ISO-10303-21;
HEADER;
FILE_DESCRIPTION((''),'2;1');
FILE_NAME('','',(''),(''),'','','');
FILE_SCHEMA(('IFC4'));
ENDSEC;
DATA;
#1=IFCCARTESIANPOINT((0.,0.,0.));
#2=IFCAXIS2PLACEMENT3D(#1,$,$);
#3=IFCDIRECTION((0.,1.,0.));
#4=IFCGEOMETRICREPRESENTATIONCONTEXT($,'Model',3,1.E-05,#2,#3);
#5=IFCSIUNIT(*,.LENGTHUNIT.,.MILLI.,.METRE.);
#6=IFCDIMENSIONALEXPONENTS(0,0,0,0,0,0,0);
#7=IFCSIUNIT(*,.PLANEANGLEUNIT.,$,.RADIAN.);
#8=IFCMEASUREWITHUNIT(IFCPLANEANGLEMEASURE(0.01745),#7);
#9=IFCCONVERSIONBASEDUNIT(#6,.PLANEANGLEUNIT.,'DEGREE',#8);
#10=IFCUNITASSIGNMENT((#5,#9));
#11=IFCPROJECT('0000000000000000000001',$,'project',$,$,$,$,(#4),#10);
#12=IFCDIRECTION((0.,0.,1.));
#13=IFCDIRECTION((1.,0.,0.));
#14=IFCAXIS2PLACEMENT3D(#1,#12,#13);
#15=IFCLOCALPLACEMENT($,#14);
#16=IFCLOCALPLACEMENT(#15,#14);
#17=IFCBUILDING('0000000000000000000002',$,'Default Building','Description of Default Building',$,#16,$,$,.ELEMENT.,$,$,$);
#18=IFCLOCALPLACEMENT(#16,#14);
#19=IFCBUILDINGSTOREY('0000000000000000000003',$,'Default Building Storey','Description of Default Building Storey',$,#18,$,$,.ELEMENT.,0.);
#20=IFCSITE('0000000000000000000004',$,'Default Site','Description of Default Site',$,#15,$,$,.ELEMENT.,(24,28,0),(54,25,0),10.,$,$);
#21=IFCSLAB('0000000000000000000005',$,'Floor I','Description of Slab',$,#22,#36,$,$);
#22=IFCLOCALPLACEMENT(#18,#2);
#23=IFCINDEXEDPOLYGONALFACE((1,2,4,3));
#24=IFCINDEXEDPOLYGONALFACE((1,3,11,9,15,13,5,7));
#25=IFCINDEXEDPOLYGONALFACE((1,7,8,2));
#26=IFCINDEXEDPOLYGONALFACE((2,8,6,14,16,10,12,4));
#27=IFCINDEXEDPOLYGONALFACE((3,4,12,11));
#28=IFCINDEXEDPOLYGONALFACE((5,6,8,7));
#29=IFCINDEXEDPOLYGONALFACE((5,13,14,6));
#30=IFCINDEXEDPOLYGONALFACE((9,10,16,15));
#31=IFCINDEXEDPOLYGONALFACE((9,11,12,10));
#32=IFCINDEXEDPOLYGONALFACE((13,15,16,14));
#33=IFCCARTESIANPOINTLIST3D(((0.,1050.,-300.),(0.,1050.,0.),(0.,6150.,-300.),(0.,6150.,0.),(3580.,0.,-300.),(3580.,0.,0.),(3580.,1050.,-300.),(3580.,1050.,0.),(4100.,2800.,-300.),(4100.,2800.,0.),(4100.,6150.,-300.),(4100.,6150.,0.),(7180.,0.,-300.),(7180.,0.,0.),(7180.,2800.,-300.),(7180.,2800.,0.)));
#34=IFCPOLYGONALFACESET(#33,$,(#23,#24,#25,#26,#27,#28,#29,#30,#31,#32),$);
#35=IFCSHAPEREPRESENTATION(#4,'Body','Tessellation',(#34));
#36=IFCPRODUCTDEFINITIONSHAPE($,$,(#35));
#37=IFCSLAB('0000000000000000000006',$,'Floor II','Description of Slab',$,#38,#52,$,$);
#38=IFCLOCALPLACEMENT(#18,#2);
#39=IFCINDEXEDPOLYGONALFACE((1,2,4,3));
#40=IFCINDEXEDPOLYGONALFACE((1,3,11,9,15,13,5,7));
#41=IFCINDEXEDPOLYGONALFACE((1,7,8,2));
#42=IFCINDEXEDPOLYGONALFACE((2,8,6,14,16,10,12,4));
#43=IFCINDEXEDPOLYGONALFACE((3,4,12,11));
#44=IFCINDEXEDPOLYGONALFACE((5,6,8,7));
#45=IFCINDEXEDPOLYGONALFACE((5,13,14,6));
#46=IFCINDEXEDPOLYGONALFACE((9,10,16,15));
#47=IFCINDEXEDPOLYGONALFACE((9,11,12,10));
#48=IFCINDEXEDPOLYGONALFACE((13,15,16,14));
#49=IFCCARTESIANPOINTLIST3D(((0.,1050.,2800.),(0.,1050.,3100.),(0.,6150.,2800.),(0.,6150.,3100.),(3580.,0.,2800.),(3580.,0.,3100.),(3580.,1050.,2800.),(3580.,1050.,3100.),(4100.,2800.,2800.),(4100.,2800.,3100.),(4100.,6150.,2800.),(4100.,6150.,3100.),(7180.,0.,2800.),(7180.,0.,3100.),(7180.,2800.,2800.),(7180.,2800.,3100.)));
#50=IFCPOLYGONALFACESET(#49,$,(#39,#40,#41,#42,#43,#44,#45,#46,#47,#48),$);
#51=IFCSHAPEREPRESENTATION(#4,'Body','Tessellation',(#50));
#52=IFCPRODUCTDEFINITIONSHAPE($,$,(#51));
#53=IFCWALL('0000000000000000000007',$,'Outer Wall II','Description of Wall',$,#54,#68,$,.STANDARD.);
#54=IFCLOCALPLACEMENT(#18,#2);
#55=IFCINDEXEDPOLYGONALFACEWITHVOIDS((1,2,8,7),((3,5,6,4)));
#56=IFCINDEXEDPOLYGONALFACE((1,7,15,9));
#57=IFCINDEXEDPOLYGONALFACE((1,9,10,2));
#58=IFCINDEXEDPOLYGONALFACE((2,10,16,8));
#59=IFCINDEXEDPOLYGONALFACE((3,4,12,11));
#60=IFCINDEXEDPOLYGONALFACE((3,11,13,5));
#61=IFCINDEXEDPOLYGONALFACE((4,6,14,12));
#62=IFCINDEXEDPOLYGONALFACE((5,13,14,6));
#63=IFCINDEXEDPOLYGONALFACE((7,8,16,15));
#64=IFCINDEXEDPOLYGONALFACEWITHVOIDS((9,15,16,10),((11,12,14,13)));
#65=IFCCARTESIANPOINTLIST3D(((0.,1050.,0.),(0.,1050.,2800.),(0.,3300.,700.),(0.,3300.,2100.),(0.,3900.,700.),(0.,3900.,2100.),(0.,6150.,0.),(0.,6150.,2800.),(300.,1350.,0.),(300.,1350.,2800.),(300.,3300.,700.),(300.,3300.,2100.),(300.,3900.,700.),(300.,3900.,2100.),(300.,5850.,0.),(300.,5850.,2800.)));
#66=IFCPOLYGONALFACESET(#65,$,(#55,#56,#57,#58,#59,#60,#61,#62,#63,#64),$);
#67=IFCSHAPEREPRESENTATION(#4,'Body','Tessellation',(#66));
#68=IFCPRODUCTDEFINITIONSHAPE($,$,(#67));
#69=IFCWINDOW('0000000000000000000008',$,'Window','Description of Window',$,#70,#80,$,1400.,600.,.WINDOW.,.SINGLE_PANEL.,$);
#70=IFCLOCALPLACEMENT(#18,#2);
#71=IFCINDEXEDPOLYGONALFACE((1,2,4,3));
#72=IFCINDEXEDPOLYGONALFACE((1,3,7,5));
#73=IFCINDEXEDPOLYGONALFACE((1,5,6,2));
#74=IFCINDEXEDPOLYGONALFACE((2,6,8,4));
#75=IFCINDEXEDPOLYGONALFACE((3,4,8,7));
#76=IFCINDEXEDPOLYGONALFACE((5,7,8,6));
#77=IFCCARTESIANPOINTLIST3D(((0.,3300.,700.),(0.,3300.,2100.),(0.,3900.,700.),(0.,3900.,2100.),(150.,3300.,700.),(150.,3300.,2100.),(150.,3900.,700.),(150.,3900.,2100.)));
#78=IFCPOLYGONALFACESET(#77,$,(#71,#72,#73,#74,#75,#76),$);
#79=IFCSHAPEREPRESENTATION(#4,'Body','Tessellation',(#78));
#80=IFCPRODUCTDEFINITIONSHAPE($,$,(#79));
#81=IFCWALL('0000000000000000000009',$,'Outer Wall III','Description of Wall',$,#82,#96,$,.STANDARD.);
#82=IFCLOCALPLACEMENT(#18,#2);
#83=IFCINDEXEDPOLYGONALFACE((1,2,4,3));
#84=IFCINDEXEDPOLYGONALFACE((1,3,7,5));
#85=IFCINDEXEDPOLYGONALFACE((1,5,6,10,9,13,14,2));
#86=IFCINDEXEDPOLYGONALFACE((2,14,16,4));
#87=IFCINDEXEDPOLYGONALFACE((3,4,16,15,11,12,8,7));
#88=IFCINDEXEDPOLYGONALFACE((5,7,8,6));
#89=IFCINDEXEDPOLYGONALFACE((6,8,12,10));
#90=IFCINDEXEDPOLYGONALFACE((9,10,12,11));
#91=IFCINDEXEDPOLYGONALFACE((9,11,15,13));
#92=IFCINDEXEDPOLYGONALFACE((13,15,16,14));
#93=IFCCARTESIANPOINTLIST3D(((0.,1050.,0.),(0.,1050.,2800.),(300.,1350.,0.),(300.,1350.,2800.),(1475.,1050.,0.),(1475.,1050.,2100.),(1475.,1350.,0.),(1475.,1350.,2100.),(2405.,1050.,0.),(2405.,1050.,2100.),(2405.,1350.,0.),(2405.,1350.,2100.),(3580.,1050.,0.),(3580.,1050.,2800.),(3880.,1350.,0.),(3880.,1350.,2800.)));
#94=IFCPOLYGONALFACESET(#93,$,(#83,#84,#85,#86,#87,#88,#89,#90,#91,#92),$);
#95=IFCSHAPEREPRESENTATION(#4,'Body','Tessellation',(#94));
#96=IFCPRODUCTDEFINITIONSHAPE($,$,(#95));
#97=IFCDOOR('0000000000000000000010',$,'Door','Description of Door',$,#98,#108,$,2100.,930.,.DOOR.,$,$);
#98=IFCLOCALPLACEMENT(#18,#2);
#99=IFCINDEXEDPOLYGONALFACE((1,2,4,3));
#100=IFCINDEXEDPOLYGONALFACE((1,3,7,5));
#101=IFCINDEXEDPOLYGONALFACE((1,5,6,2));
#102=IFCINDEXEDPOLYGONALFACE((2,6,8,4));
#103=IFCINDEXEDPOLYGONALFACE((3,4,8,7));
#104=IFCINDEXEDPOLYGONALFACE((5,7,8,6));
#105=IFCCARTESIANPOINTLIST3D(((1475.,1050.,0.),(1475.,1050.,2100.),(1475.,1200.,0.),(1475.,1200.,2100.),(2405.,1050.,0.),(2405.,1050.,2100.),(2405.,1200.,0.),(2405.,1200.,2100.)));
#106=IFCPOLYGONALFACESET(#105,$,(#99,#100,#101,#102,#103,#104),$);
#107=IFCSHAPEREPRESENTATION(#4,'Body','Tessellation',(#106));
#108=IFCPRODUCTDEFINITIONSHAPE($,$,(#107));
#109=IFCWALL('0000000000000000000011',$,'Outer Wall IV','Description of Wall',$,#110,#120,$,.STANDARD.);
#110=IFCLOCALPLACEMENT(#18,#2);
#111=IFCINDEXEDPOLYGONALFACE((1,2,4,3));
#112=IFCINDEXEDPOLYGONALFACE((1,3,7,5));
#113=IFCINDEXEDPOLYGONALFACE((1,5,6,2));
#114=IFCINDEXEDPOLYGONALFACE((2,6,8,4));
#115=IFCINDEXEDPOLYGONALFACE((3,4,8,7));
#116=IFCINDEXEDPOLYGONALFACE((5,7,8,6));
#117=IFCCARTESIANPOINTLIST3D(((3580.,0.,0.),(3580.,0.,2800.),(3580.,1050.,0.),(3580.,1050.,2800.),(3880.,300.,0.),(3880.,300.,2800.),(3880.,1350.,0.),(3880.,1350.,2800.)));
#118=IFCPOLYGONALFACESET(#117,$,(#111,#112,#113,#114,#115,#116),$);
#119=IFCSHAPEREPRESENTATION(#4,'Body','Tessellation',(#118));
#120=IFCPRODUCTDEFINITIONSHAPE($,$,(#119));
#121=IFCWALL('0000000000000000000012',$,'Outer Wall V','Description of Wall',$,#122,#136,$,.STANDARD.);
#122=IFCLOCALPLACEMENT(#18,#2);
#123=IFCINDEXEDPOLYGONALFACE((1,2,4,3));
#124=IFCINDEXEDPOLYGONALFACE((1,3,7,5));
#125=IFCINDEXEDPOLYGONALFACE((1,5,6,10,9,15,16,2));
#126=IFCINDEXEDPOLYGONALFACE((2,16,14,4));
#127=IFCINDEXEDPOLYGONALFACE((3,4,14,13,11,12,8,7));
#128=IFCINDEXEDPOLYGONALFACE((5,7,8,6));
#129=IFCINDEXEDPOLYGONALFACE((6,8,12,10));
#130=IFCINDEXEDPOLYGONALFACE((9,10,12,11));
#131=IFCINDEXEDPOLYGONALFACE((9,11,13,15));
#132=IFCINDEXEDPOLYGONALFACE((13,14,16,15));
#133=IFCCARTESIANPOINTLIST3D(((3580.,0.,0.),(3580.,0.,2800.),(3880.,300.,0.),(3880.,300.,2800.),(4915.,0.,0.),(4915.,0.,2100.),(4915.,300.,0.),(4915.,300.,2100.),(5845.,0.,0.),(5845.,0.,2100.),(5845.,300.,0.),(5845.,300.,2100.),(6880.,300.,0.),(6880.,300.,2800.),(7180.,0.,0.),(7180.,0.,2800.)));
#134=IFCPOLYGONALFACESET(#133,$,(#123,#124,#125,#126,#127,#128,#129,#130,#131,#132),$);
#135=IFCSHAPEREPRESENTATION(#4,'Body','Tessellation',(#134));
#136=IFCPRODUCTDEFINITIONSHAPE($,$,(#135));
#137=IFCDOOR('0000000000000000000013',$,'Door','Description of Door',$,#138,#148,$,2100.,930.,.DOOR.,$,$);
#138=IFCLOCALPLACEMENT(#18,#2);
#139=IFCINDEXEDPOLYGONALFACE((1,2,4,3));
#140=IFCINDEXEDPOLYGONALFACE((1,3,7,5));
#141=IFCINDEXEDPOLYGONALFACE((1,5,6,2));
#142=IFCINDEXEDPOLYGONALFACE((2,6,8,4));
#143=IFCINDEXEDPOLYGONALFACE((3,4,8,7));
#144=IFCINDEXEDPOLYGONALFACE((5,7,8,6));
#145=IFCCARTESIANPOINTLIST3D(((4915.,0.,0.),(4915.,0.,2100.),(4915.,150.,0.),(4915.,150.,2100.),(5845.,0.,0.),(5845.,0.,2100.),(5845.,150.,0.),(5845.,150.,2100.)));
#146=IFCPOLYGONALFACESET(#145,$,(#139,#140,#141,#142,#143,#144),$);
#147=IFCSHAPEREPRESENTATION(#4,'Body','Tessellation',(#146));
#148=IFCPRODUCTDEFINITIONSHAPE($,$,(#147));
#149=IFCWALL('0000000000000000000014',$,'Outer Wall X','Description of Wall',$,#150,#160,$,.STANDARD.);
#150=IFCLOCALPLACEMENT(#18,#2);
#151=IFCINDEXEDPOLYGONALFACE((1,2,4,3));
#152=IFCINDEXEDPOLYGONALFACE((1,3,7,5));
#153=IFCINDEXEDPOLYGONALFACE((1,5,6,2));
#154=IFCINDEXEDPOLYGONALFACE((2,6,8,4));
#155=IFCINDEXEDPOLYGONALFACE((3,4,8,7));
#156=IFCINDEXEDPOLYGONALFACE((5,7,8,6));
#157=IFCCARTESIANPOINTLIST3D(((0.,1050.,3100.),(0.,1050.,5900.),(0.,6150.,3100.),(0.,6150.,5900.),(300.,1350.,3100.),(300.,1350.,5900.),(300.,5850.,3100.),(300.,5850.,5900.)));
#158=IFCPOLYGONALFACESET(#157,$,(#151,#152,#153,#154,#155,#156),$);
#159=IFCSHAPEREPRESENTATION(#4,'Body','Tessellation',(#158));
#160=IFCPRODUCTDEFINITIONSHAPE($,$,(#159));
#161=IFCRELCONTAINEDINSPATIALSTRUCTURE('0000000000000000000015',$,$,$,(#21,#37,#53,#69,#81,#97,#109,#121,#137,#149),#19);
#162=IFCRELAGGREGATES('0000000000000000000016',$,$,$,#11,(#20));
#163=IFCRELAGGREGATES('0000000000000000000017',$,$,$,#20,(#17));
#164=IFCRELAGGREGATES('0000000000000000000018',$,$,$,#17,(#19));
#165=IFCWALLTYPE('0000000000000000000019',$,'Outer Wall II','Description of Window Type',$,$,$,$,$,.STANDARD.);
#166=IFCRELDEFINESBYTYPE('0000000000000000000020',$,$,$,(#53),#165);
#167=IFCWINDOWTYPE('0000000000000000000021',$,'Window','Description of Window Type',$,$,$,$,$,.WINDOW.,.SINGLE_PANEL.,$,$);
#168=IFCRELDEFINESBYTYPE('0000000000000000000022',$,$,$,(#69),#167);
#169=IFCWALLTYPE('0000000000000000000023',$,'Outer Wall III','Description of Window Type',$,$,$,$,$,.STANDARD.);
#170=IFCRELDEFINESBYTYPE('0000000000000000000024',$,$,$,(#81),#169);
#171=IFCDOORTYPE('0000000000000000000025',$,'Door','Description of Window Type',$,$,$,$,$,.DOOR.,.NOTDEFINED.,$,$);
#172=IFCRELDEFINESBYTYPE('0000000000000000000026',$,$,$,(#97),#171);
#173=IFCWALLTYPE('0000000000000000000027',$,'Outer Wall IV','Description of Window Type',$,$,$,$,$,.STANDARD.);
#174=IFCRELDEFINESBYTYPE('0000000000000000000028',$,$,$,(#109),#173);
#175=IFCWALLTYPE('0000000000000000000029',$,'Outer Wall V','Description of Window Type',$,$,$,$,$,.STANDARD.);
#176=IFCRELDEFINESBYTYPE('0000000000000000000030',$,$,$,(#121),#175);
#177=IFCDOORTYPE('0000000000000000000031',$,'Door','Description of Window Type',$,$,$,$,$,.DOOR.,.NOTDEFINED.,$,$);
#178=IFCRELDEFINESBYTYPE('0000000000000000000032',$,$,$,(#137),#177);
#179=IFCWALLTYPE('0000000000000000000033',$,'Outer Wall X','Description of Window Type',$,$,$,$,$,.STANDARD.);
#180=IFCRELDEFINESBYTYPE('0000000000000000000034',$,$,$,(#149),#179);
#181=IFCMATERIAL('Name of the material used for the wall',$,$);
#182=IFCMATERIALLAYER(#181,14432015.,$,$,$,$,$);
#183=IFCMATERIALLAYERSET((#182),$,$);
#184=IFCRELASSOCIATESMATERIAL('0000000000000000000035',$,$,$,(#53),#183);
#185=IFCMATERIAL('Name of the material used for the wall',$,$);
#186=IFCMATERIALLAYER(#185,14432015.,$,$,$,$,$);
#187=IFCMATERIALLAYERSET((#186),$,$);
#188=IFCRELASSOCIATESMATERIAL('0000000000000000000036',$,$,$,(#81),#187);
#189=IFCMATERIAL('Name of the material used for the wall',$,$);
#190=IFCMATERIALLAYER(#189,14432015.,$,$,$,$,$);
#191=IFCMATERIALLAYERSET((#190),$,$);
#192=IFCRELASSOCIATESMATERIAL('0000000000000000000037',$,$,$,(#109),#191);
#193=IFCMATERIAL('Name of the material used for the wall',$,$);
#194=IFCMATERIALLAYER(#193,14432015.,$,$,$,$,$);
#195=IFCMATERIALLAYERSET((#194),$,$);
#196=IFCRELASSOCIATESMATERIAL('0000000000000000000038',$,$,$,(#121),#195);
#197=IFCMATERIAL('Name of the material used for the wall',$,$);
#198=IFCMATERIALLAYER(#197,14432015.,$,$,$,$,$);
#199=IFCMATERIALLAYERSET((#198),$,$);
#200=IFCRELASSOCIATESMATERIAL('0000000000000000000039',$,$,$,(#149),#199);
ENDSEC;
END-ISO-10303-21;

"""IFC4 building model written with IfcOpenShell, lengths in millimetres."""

from ifc_helpers import new_model, entity, si_unit, converted_unit, direction, frame, origin, origin_with_axes, place, context, project, spatial, polyline, outline, extrude, material, layer, layer_set, layer_usage, type_object, element, fill, save


model = new_model("IFC4")

# Units and contexts
model_context = context("Model", 3, precision=1e-05, world=origin(), true_north=direction((0.0, 1.0, 0.0)))
ifc_project = project(units=[si_unit("LENGTHUNIT", "METRE", prefix="MILLI"), converted_unit("PLANEANGLEUNIT", "DEGREE", entity("IfcPlaneAngleMeasure", 0.01745), si_unit("PLANEANGLEUNIT", "RADIAN"), dimensions=[0, 0, 0, 0, 0, 0, 0])], contexts=[model_context])

# Site, building, storey
site_placement = place(None, origin_with_axes())
site = spatial("IfcSite", under=ifc_project, at=site_placement, Name="Default Site", Description="Description of Default Site", CompositionType="ELEMENT", RefLatitude=(24, 28, 0), RefLongitude=(54, 25, 0), RefElevation=10.0)
building_placement = place(site_placement, origin_with_axes())
building = spatial("IfcBuilding", under=site, at=building_placement, Name="Default Building", Description="Description of Default Building", CompositionType="ELEMENT")
storey_placement = place(building_placement, origin_with_axes())
storey = spatial("IfcBuildingStorey", under=building, at=storey_placement, Name="Default Building Storey", Description="Description of Default Building Storey", CompositionType="ELEMENT", Elevation=0.0)

# Slabs
for number, where, z_axis, x_axis, name in (
    (1, (0.0, 0.0, -300.0), (0.0, 0.0, 1.0), (1.0, 0.0, 0.0), "Floor I"),
    (2, (0.0, 0.0, 2800.0), (0.0, 0.0, 1.0), (1.0, 0.0, 0.0), "Floor II"),
):
    element("IfcSlab", number, at=place(storey_placement, frame(where, z_axis=z_axis, x_axis=x_axis)), inside=storey, Name=name, Description="Description of Slab", context=model_context, shape_type="SweptSolid", body=[
        extrude(outline(polyline([(0.0, 1050.0), (0.0, 6150.0), (4100.0, 6150.0), (4100.0, 2800.0), (7180.0, 2800.0), (7180.0, 0.0), (3580.0, 0.0), (3580.0, 1050.0), (0.0, 1050.0)])), origin_with_axes(), (0.0, 0.0, 1.0), 300.0),
    ])

# Wall, opening, window
ifc_material_1 = material(Name="Name of the material used for the wall")
ifc_layer_1 = layer(ifc_material_1, 14432015.0)
ifc_layer_set_1 = layer_set([ifc_layer_1])
ifc_layer_usage_1 = layer_usage(ifc_layer_set_1, "AXIS2", "POSITIVE", -7216007.5)
wall_type_1 = type_object("IfcWallType", Name="Outer Wall II", Description="Description of Window Type", PredefinedType="STANDARD")
wall_1_placement = place(storey_placement, frame((150.0, 6000.0, 0.0), z_axis=(0.0, 0.0, 1.0), x_axis=(0.0, -1.0, 0.0)))
wall_1 = element("IfcWall", 3, at=wall_1_placement, inside=storey, type_object=wall_type_1, material=ifc_layer_usage_1, Name="Outer Wall II", Description="Description of Wall", PredefinedType="STANDARD", context=model_context, shape_type="SweptSolid", body=[
    extrude(outline(polyline([(-150.0, -150.0), (150.0, 150.0), (4650.0, 150.0), (4950.0, -150.0), (-150.0, -150.0)])), origin_with_axes(), (0.0, 0.0, 1.0), 2800.0),
])
opening_1_placement = place(wall_1_placement, frame((2100.0, -150.0, 700.0), z_axis=(0.0, 0.0, 1.0), x_axis=(1.0, 0.0, 0.0)))
opening_1 = element("IfcOpeningElement", 4, at=opening_1_placement, cuts=wall_1, context=model_context, shape_type="SweptSolid", body=[
    extrude(outline(polyline([(0.0, 0.0), (0.0, 300.0), (600.0, 300.0), (600.0, 0.0), (0.0, 0.0)])), origin_with_axes(), (0.0, 0.0, 1.0), 1400.0),
])
window_type_1 = type_object("IfcWindowType", Name="Window", Description="Description of Window Type", PartitioningType="SINGLE_PANEL", PredefinedType="WINDOW")
window_1_placement = place(opening_1_placement, origin_with_axes())
window_1 = element("IfcWindow", 5, at=window_1_placement, inside=storey, type_object=window_type_1, Name="Window", Description="Description of Window", OverallHeight=1400.0, OverallWidth=600.0, PartitioningType="SINGLE_PANEL", PredefinedType="WINDOW", context=model_context, shape_type="SweptSolid", body=[
    extrude(outline(polyline([(0.0, 0.0), (0.0, 150.0), (600.0, 150.0), (600.0, 0.0), (0.0, 0.0)])), origin_with_axes(), (0.0, 0.0, 1.0), 1400.0),
])
fill(opening_1, window_1)

# Wall, opening, door
ifc_material_2 = material(Name="Name of the material used for the wall")
ifc_layer_2 = layer(ifc_material_2, 14432015.0)
ifc_layer_set_2 = layer_set([ifc_layer_2])
ifc_layer_usage_2 = layer_usage(ifc_layer_set_2, "AXIS2", "POSITIVE", -7216007.5)
wall_type_2 = type_object("IfcWallType", Name="Outer Wall III", Description="Description of Window Type", PredefinedType="STANDARD")
wall_2_placement = place(storey_placement, frame((150.0, 1200.0, 0.0), z_axis=(0.0, 0.0, 1.0), x_axis=(1.0, 0.0, 0.0)))
wall_2 = element("IfcWall", 6, at=wall_2_placement, inside=storey, type_object=wall_type_2, material=ifc_layer_usage_2, Name="Outer Wall III", Description="Description of Wall", PredefinedType="STANDARD", context=model_context, shape_type="SweptSolid", body=[
    extrude(outline(polyline([(-150.0, -150.0), (150.0, 150.0), (3730.0, 150.0), (3430.0, -150.0), (-150.0, -150.0)])), origin_with_axes(), (0.0, 0.0, 1.0), 2800.0),
])
opening_2_placement = place(wall_2_placement, frame((1325.0, -150.0, 0.0), z_axis=(0.0, 0.0, 1.0), x_axis=(1.0, 0.0, 0.0)))
opening_2 = element("IfcOpeningElement", 7, at=opening_2_placement, cuts=wall_2, context=model_context, shape_type="SweptSolid", body=[
    extrude(outline(polyline([(0.0, 0.0), (0.0, 300.0), (930.0, 300.0), (930.0, 0.0), (0.0, 0.0)])), origin_with_axes(), (0.0, 0.0, 1.0), 2100.0),
])
door_type_1 = type_object("IfcDoorType", Name="Door", Description="Description of Window Type", PredefinedType="DOOR")
door_1_placement = place(opening_2_placement, origin_with_axes())
door_1 = element("IfcDoor", 8, at=door_1_placement, inside=storey, type_object=door_type_1, Name="Door", Description="Description of Door", OverallHeight=2100.0, OverallWidth=930.0, PredefinedType="DOOR", context=model_context, shape_type="SweptSolid", body=[
    extrude(outline(polyline([(0.0, 0.0), (0.0, 150.0), (930.0, 150.0), (930.0, 0.0), (0.0, 0.0)])), origin_with_axes(), (0.0, 0.0, 1.0), 2100.0),
])
fill(opening_2, door_1)

# Wall
ifc_material_3 = material(Name="Name of the material used for the wall")
ifc_layer_3 = layer(ifc_material_3, 14432015.0)
ifc_layer_set_3 = layer_set([ifc_layer_3])
ifc_layer_usage_3 = layer_usage(ifc_layer_set_3, "AXIS2", "POSITIVE", -7216007.5)
wall_type_3 = type_object("IfcWallType", Name="Outer Wall IV", Description="Description of Window Type", PredefinedType="STANDARD")
wall_3_placement = place(storey_placement, frame((3730.0, 1200.0, 0.0), z_axis=(0.0, 0.0, 1.0), x_axis=(0.0, -1.0, 0.0)))
element("IfcWall", 9, at=wall_3_placement, inside=storey, type_object=wall_type_3, material=ifc_layer_usage_3, Name="Outer Wall IV", Description="Description of Wall", PredefinedType="STANDARD", context=model_context, shape_type="SweptSolid", body=[
    extrude(outline(polyline([(150.0, -150.0), (-150.0, 150.0), (900.0, 150.0), (1200.0, -150.0), (150.0, -150.0)])), origin_with_axes(), (0.0, 0.0, 1.0), 2800.0),
])

# Wall, opening, door
ifc_material_4 = material(Name="Name of the material used for the wall")
ifc_layer_4 = layer(ifc_material_4, 14432015.0)
ifc_layer_set_4 = layer_set([ifc_layer_4])
ifc_layer_usage_4 = layer_usage(ifc_layer_set_4, "AXIS2", "POSITIVE", -7216007.5)
wall_type_4 = type_object("IfcWallType", Name="Outer Wall V", Description="Description of Window Type", PredefinedType="STANDARD")
wall_4_placement = place(storey_placement, frame((3730.0, 150.0, 0.0), z_axis=(0.0, 0.0, 1.0), x_axis=(1.0, 0.0, 0.0)))
wall_4 = element("IfcWall", 10, at=wall_4_placement, inside=storey, type_object=wall_type_4, material=ifc_layer_usage_4, Name="Outer Wall V", Description="Description of Wall", PredefinedType="STANDARD", context=model_context, shape_type="SweptSolid", body=[
    extrude(outline(polyline([(-150.0, -150.0), (150.0, 150.0), (3150.0, 150.0), (3450.0, -150.0), (-150.0, -150.0)])), origin_with_axes(), (0.0, 0.0, 1.0), 2800.0),
])
opening_3_placement = place(wall_4_placement, frame((1185.0, -150.0, 0.0), z_axis=(0.0, 0.0, 1.0), x_axis=(1.0, 0.0, 0.0)))
opening_3 = element("IfcOpeningElement", 11, at=opening_3_placement, cuts=wall_4, context=model_context, shape_type="SweptSolid", body=[
    extrude(outline(polyline([(0.0, 0.0), (0.0, 300.0), (930.0, 300.0), (930.0, 0.0), (0.0, 0.0)])), origin_with_axes(), (0.0, 0.0, 1.0), 2100.0),
])
door_type_2 = type_object("IfcDoorType", Name="Door", Description="Description of Window Type", PredefinedType="DOOR")
door_2_placement = place(opening_3_placement, origin_with_axes())
door_2 = element("IfcDoor", 12, at=door_2_placement, inside=storey, type_object=door_type_2, Name="Door", Description="Description of Door", OverallHeight=2100.0, OverallWidth=930.0, PredefinedType="DOOR", context=model_context, shape_type="SweptSolid", body=[
    extrude(outline(polyline([(0.0, 0.0), (0.0, 150.0), (930.0, 150.0), (930.0, 0.0), (0.0, 0.0)])), origin_with_axes(), (0.0, 0.0, 1.0), 2100.0),
])
fill(opening_3, door_2)

# Wall
ifc_material_5 = material(Name="Name of the material used for the wall")
ifc_layer_5 = layer(ifc_material_5, 14432015.0)
ifc_layer_set_5 = layer_set([ifc_layer_5])
ifc_layer_usage_5 = layer_usage(ifc_layer_set_5, "AXIS2", "POSITIVE", -7216007.5)
wall_type_5 = type_object("IfcWallType", Name="Outer Wall X", Description="Description of Window Type", PredefinedType="STANDARD")
wall_5_placement = place(storey_placement, frame((150.0, 6000.0, 3100.0), z_axis=(0.0, 0.0, 1.0), x_axis=(0.0, -1.0, 0.0)))
element("IfcWall", 13, at=wall_5_placement, inside=storey, type_object=wall_type_5, material=ifc_layer_usage_5, Name="Outer Wall X", Description="Description of Wall", PredefinedType="STANDARD", context=model_context, shape_type="SweptSolid", body=[
    extrude(outline(polyline([(-150.0, -150.0), (150.0, 150.0), (4650.0, 150.0), (4950.0, -150.0), (-150.0, -150.0)])), origin_with_axes(), (0.0, 0.0, 1.0), 2800.0),
])

save(model, "model.ifc")
